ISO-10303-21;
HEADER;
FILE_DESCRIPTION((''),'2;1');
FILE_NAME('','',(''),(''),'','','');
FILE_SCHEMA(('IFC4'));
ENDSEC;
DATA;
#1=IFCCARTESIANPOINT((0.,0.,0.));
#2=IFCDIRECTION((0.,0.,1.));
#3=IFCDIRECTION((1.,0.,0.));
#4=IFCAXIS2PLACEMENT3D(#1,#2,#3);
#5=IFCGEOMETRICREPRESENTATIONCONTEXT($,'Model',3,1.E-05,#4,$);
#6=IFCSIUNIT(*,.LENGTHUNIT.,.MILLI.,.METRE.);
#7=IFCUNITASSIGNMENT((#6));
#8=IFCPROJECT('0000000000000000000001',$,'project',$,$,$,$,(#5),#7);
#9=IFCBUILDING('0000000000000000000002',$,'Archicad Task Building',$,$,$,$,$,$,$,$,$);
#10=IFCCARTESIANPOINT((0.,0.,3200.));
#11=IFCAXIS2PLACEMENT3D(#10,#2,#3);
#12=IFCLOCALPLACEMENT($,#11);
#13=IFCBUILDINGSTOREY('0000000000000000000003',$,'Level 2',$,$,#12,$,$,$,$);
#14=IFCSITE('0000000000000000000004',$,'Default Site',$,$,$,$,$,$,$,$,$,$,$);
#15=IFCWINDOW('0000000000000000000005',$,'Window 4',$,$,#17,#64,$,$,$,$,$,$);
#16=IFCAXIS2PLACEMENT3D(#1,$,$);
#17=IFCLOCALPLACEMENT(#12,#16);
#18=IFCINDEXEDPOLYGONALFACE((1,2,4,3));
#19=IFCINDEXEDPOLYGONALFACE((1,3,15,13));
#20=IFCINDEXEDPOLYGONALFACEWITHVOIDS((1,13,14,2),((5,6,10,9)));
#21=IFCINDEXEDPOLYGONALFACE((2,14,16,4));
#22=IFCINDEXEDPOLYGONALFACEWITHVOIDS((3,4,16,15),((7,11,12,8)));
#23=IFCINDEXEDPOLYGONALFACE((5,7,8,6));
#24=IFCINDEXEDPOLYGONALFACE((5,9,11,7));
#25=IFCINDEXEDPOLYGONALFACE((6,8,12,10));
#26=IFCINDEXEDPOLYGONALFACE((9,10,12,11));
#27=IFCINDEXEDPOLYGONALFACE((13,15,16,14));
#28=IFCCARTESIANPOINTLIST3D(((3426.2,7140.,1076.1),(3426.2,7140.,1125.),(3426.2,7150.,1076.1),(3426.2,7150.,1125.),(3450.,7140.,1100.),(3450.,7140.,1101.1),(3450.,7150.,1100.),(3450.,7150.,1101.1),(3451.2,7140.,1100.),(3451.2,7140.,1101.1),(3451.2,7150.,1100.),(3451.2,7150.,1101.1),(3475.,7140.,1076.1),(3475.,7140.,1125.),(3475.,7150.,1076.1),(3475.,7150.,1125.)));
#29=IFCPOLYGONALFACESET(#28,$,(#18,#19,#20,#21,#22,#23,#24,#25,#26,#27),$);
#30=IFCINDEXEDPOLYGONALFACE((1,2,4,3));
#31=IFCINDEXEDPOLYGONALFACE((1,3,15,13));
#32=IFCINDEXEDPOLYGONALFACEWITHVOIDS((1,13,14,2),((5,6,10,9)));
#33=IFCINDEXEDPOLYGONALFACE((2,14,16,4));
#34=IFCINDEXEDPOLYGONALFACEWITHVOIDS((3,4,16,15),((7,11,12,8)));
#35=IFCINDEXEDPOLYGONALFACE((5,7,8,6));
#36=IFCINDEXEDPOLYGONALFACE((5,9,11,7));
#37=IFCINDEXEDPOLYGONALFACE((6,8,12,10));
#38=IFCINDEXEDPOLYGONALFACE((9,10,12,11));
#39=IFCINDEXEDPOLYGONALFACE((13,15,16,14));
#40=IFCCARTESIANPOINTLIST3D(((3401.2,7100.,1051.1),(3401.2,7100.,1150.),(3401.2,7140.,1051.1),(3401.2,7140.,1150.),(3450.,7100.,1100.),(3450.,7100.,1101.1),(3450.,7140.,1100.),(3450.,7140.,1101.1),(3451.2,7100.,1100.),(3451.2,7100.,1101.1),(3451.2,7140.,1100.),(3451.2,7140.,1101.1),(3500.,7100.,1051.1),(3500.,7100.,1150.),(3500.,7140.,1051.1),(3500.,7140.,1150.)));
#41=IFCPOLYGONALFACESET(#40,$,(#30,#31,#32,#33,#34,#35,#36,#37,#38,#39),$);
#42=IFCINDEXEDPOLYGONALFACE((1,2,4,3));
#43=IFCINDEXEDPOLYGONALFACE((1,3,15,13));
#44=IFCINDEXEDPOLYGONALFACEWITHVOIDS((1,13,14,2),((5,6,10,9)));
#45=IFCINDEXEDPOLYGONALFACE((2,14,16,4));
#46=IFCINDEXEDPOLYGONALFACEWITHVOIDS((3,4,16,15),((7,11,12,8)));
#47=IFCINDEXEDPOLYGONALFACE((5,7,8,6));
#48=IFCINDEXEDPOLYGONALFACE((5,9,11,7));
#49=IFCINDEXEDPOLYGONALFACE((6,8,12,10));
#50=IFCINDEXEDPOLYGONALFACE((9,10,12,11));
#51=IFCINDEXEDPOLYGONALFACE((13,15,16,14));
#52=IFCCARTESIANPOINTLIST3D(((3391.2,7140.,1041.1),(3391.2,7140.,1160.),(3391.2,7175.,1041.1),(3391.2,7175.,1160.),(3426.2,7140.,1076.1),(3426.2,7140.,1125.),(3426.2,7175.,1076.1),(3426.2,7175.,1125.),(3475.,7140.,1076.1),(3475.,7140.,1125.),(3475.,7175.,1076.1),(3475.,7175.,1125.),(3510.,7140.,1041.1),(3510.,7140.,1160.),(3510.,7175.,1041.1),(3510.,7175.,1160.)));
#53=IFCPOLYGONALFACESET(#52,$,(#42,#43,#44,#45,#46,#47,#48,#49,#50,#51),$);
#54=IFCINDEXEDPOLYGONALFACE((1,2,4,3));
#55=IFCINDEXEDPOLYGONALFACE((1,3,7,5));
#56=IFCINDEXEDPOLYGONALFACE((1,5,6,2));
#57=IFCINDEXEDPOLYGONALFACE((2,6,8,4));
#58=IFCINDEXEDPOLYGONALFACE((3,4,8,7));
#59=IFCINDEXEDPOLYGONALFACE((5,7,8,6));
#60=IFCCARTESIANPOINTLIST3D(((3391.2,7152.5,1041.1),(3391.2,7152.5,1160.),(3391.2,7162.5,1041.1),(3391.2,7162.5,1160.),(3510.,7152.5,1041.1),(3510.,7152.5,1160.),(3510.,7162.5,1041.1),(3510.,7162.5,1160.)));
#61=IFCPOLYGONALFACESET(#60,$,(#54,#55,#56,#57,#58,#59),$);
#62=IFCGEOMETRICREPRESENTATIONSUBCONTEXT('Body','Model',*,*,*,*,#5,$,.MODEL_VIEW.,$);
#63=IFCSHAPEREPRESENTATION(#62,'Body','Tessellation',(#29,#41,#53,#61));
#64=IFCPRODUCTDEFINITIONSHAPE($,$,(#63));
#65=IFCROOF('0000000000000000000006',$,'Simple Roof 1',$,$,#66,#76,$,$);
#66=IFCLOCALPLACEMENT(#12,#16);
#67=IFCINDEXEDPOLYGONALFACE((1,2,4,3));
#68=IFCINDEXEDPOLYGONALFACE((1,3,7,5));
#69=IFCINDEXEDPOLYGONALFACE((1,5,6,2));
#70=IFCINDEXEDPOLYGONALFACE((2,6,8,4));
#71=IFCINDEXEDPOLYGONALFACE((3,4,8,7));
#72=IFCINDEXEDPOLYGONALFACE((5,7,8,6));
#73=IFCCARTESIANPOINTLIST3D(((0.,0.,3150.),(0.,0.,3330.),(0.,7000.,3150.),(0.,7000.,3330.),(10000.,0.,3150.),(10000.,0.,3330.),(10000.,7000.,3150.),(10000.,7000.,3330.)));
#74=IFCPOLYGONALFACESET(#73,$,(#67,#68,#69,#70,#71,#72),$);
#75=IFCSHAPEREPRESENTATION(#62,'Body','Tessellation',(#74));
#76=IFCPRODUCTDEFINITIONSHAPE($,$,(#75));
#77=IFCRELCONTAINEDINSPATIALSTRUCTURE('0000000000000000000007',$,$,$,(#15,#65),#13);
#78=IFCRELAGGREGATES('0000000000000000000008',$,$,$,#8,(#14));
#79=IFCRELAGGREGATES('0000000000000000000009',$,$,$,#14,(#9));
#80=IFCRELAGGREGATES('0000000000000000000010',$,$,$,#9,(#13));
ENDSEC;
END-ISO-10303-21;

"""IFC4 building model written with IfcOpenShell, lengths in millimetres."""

from ifc_helpers import new_model, si_unit, frame, origin_with_axes, place, context, subcontext, project, spatial, line, indexed_curve, outline, extrude, element, save


model = new_model("IFC4")

# Units and contexts
model_context = context("Model", 3, precision=1e-05, world=origin_with_axes())
body_context = subcontext(model_context, "Body", "Model", "MODEL_VIEW")
ifc_project = project(units=[si_unit("LENGTHUNIT", "METRE", prefix="MILLI")], contexts=[model_context])

# Site, building, storey
site = spatial("IfcSite", under=ifc_project, Name="Default Site")
building = spatial("IfcBuilding", under=site, Name="Archicad Task Building")
storey_placement = place(None, frame((0.0, 0.0, 3200.0), z_axis=(0.0, 0.0, 1.0), x_axis=(1.0, 0.0, 0.0)))
storey = spatial("IfcBuildingStorey", under=building, at=storey_placement, Name="Level 2")

# Window
for number, where, z_axis, x_axis, name in (
    (1, (3450.0, 7050.0, 1100.0), (0.0, 0.0, 1.0), (1.0, 0.0, 0.0), "Window 4"),
):
    element("IfcWindow", number, at=place(storey_placement, frame(where, z_axis=z_axis, x_axis=x_axis)), inside=storey, Name=name, context=body_context, shape_type="SweptSolid", body=[
        extrude(outline(indexed_curve([(0.0, 0.0), (1.2, 0.0), (1.2, 1.1), (0.0, 1.1)], segments=[line(1, 2, 3, 4, 1)]), holes=[indexed_curve([(25.0, 25.0), (-23.8, 25.0), (-23.8, -23.9), (25.0, -23.9)], segments=[line(1, 2, 3, 4, 1)])]), frame((0.0, 90.0, 0.0), z_axis=(0.0, -1.0, 0.0), x_axis=(1.0, 0.0, 0.0)), (0.0, 0.0, -1.0), 10.0),
        extrude(outline(indexed_curve([(0.0, 0.0), (1.2, 0.0), (1.2, 1.1), (0.0, 1.1)], segments=[line(1, 2, 3, 4, 1)]), holes=[indexed_curve([(50.0, 50.0), (-48.8, 50.0), (-48.8, -48.9), (50.0, -48.9)], segments=[line(1, 2, 3, 4, 1)])]), frame((0.0, 50.0, 0.0), z_axis=(0.0, -1.0, 0.0), x_axis=(1.0, 0.0, 0.0)), (0.0, 0.0, -1.0), 40.0),
        extrude(outline(indexed_curve([(0.0, 0.0), (-48.8, 0.0), (-48.8, -48.9), (0.0, -48.9)], segments=[line(1, 2, 3, 4, 1)]), holes=[indexed_curve([(35.0, 35.0), (-83.8, 35.0), (-83.8, -83.9), (35.0, -83.9)], segments=[line(1, 2, 3, 4, 1)])]), frame((25.0, 90.0, 25.0), z_axis=(0.0, -1.0, 0.0), x_axis=(1.0, 0.0, 0.0)), (0.0, 0.0, -1.0), 35.0),
        extrude(outline(indexed_curve([(35.0, 35.0), (-83.8, 35.0), (-83.8, -83.9), (35.0, -83.9)], segments=[line(1, 2, 3, 4, 1)])), frame((25.0, 102.5, 25.0), z_axis=(0.0, -1.0, 0.0), x_axis=(1.0, 0.0, 0.0)), (0.0, 0.0, -1.0), 10.0),
    ])

# Roof
roof_placement = place(storey_placement, frame((0.0, 0.0, 3150.0), z_axis=(0.0, 0.0, 1.0), x_axis=(1.0, 0.0, 0.0)))
element("IfcRoof", 2, at=roof_placement, inside=storey, Name="Simple Roof 1", context=body_context, shape_type="SweptSolid", body=[
    extrude(outline(indexed_curve([(0.0, 0.0), (10000.0, 0.0), (10000.0, 7000.0), (0.0, 7000.0), (0.0, 0.0)])), None, (0.0, 0.0, 1.0), 180.0),
])

save(model, "model.ifc")
